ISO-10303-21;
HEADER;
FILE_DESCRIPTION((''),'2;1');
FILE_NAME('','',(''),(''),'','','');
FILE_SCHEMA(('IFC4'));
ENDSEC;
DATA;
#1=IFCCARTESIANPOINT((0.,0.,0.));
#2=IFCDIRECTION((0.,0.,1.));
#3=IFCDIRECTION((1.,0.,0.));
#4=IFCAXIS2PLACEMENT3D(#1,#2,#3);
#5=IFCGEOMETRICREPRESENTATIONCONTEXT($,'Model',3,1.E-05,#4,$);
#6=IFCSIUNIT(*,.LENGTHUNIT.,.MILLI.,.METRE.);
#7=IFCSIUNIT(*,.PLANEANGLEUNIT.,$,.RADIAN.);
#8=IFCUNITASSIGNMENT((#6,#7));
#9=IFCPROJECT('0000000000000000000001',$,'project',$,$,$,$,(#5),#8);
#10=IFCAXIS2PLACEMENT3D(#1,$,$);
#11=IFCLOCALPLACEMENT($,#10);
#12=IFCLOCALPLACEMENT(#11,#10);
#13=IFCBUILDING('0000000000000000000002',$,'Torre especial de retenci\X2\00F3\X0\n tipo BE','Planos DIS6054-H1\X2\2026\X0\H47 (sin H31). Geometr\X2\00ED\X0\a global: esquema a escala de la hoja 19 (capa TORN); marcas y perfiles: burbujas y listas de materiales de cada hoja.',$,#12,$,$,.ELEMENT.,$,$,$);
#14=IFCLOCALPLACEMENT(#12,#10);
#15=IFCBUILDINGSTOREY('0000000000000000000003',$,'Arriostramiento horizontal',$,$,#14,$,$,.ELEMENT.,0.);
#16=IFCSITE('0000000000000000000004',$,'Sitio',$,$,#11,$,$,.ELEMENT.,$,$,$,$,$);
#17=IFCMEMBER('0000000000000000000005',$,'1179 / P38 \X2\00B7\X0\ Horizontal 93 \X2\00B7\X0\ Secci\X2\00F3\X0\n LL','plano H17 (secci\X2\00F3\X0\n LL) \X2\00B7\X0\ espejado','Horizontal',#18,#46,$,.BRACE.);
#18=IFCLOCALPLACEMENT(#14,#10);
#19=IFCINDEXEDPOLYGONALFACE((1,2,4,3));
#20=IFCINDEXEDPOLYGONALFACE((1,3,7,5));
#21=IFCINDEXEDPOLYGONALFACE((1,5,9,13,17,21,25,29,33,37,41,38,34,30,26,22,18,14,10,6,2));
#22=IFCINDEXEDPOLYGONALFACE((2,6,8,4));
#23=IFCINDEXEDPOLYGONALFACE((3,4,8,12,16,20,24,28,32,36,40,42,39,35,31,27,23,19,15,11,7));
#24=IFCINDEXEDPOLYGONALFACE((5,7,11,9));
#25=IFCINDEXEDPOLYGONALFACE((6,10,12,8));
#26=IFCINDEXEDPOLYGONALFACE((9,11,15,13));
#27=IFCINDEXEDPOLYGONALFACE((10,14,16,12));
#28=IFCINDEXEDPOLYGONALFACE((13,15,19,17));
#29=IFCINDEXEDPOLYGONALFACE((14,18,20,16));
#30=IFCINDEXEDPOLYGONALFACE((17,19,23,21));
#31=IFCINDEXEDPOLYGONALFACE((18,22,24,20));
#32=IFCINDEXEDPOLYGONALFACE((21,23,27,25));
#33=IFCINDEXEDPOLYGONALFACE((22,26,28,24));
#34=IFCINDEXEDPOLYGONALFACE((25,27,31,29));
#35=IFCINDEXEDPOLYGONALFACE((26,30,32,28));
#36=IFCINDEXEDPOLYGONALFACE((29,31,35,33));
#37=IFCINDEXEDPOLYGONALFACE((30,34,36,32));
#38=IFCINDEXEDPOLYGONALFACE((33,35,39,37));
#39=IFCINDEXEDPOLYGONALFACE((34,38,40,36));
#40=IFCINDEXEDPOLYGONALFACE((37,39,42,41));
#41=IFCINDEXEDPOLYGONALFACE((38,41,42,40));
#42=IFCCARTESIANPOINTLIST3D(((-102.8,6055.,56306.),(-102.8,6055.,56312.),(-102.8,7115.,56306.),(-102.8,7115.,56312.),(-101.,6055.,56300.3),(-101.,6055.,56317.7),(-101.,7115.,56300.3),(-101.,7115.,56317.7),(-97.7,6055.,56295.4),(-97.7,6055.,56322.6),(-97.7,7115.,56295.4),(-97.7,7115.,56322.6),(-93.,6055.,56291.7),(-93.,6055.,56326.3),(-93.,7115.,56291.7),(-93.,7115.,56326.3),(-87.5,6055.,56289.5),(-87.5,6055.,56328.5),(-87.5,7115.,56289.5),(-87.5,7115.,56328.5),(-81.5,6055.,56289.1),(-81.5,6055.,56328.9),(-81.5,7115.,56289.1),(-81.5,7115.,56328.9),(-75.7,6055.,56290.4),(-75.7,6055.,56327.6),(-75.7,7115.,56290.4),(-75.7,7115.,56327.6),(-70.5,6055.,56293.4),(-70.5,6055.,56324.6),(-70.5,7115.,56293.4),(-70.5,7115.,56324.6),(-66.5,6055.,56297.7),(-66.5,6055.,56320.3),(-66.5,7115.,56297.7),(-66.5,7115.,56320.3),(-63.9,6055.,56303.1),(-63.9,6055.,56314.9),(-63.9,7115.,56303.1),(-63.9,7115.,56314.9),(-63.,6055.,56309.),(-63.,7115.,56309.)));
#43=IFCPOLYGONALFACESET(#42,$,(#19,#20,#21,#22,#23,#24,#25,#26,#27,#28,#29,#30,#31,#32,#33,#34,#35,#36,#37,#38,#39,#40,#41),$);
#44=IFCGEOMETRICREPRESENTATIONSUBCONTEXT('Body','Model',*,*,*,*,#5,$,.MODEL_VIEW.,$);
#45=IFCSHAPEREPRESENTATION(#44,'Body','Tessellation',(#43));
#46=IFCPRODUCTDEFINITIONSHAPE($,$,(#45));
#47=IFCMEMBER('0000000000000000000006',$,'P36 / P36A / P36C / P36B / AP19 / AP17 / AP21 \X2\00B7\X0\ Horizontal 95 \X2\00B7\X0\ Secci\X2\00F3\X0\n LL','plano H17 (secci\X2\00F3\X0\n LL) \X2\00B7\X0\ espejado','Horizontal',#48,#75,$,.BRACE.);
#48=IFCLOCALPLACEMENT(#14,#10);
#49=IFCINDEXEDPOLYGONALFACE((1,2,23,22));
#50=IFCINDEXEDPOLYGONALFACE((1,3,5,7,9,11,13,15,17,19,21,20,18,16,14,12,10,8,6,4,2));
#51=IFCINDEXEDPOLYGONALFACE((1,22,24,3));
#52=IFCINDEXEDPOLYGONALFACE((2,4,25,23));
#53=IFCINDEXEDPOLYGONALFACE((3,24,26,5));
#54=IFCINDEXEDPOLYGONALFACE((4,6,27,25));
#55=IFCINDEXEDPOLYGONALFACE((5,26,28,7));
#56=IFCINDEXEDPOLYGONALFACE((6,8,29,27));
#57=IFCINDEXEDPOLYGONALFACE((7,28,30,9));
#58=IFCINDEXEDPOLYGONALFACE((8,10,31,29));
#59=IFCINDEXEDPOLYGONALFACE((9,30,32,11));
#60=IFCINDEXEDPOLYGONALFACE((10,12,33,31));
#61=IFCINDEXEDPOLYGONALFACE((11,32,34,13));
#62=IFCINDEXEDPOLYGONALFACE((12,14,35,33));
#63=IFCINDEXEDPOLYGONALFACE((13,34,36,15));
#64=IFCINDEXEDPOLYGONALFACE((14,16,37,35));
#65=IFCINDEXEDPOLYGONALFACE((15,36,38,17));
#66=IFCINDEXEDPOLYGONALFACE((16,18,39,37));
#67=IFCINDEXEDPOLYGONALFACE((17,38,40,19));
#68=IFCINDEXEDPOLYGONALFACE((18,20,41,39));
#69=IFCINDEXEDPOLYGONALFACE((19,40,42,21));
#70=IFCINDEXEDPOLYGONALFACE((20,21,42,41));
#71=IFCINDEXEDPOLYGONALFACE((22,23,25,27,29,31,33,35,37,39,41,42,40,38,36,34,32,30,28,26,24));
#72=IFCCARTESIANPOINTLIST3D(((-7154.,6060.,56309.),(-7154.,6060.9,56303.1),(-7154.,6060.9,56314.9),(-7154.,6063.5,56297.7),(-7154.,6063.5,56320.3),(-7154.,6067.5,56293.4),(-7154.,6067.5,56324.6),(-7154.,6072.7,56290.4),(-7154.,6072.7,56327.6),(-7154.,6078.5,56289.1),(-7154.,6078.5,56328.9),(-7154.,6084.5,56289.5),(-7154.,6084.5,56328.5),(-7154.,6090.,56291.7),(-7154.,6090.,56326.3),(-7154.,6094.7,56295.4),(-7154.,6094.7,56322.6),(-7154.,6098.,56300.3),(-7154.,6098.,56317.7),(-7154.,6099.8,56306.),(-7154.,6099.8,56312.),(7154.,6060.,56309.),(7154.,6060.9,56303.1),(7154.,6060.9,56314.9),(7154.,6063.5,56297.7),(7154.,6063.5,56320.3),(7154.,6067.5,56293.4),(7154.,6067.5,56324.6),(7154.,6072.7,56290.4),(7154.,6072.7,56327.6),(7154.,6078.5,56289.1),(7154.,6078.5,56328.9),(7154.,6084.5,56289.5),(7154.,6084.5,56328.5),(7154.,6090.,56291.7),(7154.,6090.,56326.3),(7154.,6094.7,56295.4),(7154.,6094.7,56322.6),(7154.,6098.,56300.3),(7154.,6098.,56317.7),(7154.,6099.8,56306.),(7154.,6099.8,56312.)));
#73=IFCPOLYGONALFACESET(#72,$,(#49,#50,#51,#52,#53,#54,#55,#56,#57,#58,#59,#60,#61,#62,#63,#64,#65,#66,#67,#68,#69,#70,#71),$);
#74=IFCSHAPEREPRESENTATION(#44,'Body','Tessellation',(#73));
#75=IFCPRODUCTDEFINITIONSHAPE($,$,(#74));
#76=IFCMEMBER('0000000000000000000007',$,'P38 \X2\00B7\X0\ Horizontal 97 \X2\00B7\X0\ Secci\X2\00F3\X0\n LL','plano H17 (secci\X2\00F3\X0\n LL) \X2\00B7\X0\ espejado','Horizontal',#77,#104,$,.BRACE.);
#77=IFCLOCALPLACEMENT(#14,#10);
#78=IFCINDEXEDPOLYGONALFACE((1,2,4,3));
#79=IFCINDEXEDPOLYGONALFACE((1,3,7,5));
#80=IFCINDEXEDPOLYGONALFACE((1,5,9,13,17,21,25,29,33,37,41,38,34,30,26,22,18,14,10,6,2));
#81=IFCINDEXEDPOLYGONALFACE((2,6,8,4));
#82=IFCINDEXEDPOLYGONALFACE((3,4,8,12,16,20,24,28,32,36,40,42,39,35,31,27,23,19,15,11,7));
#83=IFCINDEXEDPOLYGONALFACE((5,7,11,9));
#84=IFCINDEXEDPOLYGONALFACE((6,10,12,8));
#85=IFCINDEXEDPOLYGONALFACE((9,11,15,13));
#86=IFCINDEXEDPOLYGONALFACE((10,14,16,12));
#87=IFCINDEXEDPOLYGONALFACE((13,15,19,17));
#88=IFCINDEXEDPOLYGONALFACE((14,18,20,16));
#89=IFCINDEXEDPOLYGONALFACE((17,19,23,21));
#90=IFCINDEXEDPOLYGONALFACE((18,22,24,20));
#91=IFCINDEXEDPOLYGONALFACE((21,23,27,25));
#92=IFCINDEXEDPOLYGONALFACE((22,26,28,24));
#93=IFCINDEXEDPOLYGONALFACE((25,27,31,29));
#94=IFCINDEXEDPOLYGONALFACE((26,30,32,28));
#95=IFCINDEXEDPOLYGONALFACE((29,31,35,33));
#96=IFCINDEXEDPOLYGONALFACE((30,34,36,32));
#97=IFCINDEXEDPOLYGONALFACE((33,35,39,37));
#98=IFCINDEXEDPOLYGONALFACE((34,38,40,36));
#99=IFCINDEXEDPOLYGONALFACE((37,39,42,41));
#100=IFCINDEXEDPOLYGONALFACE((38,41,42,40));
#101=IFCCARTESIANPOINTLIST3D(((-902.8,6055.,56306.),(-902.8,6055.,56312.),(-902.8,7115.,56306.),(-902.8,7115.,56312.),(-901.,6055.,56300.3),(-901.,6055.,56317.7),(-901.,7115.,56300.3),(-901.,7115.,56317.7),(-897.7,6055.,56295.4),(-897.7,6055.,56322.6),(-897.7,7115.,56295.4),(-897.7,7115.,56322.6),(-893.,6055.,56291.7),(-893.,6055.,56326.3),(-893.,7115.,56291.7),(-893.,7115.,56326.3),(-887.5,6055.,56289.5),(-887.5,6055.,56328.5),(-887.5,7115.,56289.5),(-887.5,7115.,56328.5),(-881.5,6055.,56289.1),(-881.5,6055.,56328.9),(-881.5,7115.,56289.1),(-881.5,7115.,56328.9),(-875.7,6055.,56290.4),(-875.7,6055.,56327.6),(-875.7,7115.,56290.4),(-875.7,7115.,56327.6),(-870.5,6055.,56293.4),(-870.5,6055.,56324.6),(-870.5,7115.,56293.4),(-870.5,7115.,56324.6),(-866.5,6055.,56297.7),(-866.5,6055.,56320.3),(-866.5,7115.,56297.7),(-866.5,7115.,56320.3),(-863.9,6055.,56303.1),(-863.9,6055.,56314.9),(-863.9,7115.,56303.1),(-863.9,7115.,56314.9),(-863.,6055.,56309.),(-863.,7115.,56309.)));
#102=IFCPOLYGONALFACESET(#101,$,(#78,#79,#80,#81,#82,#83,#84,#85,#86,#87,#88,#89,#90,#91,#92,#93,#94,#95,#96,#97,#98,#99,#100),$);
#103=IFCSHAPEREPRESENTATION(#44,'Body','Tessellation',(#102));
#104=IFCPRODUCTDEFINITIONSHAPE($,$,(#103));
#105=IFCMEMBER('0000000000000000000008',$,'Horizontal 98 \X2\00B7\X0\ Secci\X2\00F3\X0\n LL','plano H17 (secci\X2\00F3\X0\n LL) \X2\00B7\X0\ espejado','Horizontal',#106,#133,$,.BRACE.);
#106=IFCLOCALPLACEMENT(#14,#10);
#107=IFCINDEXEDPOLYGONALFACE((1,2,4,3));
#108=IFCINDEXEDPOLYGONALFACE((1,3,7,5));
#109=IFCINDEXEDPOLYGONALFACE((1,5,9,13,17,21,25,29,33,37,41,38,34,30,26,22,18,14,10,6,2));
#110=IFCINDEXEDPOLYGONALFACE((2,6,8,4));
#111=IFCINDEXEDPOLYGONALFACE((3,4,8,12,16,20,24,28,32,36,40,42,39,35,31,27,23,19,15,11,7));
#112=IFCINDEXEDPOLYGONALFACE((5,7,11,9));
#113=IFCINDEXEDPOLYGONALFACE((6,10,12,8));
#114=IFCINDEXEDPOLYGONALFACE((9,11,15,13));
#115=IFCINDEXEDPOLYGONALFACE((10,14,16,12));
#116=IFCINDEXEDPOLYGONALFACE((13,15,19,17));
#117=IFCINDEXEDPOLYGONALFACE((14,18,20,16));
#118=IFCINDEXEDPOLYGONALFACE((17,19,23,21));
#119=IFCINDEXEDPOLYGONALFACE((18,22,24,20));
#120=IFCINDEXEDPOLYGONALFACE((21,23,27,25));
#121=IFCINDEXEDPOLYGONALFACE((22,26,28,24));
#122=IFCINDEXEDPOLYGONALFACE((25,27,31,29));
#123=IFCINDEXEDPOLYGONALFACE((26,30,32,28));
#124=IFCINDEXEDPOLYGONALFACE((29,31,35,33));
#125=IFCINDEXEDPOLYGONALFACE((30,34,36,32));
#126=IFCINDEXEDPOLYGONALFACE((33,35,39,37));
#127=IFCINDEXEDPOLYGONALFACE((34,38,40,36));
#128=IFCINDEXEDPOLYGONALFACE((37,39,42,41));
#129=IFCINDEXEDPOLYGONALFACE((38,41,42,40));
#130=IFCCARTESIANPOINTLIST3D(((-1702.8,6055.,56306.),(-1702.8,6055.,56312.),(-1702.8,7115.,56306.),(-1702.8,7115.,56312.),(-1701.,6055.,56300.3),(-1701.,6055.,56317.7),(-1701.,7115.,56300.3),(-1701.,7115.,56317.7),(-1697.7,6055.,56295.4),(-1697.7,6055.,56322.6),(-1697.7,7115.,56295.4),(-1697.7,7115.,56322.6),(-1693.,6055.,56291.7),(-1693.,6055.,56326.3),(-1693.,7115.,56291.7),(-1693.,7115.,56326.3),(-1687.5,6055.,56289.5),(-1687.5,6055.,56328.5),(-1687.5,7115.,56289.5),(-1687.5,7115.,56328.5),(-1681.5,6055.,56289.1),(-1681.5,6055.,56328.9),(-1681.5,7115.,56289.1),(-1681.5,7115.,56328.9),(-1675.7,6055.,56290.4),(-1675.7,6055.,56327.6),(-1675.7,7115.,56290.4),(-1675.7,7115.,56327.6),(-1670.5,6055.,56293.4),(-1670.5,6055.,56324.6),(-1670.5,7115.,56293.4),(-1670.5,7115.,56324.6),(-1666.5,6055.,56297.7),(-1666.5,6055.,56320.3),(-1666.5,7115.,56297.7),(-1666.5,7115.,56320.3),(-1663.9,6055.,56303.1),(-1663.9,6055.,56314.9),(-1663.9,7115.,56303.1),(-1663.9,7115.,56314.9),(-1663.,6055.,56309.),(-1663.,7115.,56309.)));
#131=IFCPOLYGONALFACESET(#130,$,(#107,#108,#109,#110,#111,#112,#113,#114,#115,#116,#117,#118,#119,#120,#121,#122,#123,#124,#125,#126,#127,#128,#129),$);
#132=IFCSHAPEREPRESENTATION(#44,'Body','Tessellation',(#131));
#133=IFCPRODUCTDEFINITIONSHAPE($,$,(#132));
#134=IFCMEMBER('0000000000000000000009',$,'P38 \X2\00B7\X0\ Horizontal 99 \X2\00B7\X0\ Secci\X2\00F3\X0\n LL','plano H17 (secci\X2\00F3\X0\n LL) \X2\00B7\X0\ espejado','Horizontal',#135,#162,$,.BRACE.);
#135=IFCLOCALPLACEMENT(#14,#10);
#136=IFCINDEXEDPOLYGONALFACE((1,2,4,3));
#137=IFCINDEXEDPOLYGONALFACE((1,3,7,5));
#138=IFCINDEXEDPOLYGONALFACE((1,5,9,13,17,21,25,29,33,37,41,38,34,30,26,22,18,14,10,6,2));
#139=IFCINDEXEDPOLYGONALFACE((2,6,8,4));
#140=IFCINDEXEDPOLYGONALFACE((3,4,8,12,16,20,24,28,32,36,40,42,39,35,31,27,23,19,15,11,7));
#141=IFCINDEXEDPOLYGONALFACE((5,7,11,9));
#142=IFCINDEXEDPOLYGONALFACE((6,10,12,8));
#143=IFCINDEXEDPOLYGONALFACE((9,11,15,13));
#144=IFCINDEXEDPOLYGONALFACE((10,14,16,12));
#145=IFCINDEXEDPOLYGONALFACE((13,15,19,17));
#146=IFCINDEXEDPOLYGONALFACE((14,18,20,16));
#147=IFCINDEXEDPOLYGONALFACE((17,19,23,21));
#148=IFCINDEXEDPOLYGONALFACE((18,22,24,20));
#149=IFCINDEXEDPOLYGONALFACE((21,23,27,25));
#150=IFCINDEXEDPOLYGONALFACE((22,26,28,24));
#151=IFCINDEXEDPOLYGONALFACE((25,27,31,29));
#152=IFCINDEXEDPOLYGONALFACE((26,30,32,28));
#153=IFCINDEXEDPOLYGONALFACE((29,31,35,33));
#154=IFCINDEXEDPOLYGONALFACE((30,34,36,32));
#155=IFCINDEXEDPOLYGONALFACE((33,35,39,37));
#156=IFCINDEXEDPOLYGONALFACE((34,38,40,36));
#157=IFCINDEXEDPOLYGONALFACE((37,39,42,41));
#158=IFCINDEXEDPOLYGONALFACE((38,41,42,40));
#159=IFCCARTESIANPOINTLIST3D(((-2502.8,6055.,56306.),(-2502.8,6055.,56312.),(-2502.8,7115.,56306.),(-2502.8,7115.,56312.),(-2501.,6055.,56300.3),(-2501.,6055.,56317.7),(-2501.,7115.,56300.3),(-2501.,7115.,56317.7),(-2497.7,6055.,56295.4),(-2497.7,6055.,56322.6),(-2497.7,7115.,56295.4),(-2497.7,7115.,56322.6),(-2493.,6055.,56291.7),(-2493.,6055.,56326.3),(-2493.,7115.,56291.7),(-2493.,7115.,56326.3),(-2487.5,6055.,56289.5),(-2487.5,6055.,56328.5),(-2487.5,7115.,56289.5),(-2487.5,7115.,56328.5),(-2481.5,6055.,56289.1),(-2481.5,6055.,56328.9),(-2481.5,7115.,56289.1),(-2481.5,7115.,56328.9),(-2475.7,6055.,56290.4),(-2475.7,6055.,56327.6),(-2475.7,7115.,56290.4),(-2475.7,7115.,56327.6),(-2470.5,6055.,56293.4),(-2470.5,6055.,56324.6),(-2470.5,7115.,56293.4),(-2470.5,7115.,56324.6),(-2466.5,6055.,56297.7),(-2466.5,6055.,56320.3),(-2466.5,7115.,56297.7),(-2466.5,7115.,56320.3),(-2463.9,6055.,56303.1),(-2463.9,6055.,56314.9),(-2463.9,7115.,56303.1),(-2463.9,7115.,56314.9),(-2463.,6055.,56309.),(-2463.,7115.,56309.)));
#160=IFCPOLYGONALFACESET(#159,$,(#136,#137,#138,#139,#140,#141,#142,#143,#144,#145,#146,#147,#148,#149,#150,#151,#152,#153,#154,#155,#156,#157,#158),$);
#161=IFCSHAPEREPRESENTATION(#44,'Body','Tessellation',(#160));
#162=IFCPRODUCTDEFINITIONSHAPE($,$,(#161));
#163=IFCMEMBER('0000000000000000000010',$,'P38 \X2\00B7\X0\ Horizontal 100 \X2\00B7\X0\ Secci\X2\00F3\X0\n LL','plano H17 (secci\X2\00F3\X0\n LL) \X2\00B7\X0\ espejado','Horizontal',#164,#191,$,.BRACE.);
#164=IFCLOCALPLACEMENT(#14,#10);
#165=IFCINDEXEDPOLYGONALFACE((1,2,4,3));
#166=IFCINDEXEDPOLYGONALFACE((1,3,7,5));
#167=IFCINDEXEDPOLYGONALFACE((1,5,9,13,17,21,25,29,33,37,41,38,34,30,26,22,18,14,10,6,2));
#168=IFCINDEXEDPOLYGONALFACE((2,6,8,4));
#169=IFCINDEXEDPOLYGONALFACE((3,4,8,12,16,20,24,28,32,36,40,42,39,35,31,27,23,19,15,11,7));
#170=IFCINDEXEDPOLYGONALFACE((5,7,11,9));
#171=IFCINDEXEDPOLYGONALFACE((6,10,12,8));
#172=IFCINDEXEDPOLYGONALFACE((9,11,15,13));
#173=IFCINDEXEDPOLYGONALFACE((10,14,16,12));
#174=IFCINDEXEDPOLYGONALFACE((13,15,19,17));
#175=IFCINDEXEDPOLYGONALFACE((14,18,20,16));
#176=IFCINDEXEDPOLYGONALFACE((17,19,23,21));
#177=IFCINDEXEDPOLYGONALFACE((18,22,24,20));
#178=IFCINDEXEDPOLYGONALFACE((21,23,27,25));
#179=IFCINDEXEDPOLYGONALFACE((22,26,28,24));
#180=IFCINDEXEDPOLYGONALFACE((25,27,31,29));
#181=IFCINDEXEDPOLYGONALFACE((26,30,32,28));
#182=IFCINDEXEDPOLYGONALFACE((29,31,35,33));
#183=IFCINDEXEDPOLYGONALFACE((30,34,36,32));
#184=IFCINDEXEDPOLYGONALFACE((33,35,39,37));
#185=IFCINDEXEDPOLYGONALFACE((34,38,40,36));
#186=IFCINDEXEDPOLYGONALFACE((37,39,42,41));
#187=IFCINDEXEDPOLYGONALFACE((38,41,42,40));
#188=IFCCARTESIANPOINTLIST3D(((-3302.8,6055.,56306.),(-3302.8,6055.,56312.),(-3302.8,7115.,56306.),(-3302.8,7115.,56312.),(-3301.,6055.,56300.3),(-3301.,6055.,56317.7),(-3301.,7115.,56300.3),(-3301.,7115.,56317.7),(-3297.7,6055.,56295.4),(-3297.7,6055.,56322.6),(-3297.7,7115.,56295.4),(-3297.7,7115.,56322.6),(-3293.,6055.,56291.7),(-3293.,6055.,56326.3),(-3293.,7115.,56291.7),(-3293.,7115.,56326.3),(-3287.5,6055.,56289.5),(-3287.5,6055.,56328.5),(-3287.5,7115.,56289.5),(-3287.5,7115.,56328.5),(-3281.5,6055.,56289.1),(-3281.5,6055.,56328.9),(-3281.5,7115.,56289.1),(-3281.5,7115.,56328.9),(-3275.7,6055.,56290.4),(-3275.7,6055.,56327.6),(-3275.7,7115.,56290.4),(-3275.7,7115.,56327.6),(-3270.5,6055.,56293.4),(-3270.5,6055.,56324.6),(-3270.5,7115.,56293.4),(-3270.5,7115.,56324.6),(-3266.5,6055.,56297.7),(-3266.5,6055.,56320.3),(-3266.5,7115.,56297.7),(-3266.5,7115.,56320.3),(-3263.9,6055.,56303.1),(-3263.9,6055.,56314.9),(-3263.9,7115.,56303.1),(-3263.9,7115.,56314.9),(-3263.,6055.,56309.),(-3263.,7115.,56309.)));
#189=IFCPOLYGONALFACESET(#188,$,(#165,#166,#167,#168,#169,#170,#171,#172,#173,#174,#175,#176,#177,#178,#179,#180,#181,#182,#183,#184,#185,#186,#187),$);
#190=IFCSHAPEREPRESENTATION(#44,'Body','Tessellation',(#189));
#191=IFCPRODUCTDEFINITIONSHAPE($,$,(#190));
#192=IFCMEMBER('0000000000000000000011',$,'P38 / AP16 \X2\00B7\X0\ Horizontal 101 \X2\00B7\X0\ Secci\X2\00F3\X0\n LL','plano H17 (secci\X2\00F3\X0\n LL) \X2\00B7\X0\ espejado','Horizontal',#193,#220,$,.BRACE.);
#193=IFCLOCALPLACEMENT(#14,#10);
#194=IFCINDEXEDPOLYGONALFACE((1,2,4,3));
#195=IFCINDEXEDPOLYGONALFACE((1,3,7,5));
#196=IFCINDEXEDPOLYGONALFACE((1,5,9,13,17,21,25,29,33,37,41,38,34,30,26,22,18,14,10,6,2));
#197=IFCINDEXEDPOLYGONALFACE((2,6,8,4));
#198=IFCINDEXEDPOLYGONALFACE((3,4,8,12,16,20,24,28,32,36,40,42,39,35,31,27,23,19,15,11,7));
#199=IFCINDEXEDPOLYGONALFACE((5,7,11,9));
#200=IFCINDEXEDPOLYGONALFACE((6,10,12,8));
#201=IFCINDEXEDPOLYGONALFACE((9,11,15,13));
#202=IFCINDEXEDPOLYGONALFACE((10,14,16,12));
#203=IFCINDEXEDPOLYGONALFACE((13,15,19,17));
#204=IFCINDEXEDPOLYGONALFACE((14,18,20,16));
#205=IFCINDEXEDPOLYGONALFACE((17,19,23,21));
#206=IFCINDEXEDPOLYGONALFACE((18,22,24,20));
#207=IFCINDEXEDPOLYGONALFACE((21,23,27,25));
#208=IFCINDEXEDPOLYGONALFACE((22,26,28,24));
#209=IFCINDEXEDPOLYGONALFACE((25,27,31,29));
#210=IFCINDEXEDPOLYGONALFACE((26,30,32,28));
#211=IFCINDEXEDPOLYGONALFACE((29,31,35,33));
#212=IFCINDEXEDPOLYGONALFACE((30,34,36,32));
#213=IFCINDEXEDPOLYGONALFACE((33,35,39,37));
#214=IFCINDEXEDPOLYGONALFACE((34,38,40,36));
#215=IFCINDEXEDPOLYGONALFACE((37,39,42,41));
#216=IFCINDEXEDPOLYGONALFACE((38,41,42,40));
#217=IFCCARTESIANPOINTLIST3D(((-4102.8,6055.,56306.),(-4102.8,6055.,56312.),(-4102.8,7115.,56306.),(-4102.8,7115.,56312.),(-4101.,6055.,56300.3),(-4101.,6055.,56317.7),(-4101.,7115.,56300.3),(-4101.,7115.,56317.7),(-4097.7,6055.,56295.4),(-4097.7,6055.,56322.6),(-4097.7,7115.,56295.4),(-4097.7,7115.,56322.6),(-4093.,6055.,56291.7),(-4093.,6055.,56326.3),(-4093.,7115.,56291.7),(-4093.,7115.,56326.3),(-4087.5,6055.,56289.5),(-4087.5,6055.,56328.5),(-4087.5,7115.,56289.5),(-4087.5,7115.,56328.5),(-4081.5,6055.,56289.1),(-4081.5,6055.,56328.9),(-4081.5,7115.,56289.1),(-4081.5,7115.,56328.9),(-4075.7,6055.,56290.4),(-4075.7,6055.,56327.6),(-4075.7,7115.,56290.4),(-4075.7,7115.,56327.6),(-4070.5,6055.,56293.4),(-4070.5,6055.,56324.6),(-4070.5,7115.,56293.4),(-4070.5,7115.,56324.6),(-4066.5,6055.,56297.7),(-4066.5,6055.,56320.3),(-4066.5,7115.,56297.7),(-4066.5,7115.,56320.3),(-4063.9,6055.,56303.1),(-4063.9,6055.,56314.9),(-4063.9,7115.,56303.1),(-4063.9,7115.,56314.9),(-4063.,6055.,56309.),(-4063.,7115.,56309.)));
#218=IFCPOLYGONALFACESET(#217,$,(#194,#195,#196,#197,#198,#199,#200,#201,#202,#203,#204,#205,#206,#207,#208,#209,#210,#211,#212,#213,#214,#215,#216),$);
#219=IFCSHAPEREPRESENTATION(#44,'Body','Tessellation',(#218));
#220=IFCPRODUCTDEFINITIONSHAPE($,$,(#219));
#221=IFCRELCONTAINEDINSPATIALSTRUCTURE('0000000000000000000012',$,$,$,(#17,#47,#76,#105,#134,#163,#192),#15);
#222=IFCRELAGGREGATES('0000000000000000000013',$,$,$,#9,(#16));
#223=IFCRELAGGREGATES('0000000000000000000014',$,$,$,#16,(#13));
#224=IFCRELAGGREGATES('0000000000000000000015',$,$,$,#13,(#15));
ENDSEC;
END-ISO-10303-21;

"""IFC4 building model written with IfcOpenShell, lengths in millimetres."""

from ifc_helpers import new_model, si_unit, frame, origin, origin_with_axes, place, context, subcontext, project, spatial, circle, extrude, element, save


model = new_model("IFC4")

# Units and contexts
model_context = context("Model", 3, precision=1e-05, world=origin_with_axes())
body_context = subcontext(model_context, "Body", "Model", "MODEL_VIEW")
ifc_project = project(units=[si_unit("LENGTHUNIT", "METRE", prefix="MILLI"), si_unit("PLANEANGLEUNIT", "RADIAN")], contexts=[model_context])

# Site, building, storey
site_placement = place(None, origin())
site = spatial("IfcSite", under=ifc_project, at=site_placement, Name="Sitio", CompositionType="ELEMENT")
building_placement = place(site_placement, origin())
building = spatial("IfcBuilding", under=site, at=building_placement, Name="Torre especial de retención tipo BE", Description="Planos DIS6054-H1…H47 (sin H31). Geometría global: esquema a escala de la hoja 19 (capa TORN); marcas y perfiles: burbujas y listas de materiales de cada hoja.", CompositionType="ELEMENT")
storey_placement = place(building_placement, origin())
storey = spatial("IfcBuildingStorey", under=building, at=storey_placement, Name="Arriostramiento horizontal", CompositionType="ELEMENT", Elevation=0.0)

# Members
member_1_placement = place(storey_placement, frame((-83.0, 7115.0, 56309.0), z_axis=(0.0, -1.0, 0.0), x_axis=(1.0, 0.0, 0.0)))
element("IfcMember", 1, at=member_1_placement, inside=storey, Name="1179 / P38 · Horizontal 93 · Sección LL", Description="plano H17 (sección LL) · espejado", ObjectType="Horizontal", PredefinedType="BRACE", context=body_context, shape_type="SweptSolid", body=[
    extrude(circle(Radius=20.0), None, (0.0, 0.0, 1.0), 1060.0),
])
member_2_placement = place(storey_placement, frame((-7154.0, 6080.0, 56309.0), z_axis=(1.0, 0.0, 0.0), x_axis=(0.0, -1.0, 0.0)))
element("IfcMember", 2, at=member_2_placement, inside=storey, Name="P36 / P36A / P36C / P36B / AP19 / AP17 / AP21 · Horizontal 95 · Sección LL", Description="plano H17 (sección LL) · espejado", ObjectType="Horizontal", PredefinedType="BRACE", context=body_context, shape_type="SweptSolid", body=[
    extrude(circle(Radius=20.0), None, (0.0, 0.0, 1.0), 14308.0),
])
for number, where, z_axis, x_axis, name in (
    (3, (-883.0, 7115.0, 56309.0), (0.0, -1.0, 0.0), (1.0, 0.0, 0.0), "P38 · Horizontal 97 · Sección LL"),
    (4, (-1683.0, 7115.0, 56309.0), (0.0, -1.0, 0.0), (1.0, 0.0, 0.0), "Horizontal 98 · Sección LL"),
    (5, (-2483.0, 7115.0, 56309.0), (0.0, -1.0, 0.0), (1.0, 0.0, 0.0), "P38 · Horizontal 99 · Sección LL"),
    (6, (-3283.0, 7115.0, 56309.0), (0.0, -1.0, 0.0), (1.0, 0.0, 0.0), "P38 · Horizontal 100 · Sección LL"),
    (7, (-4083.0, 7115.0, 56309.0), (0.0, -1.0, 0.0), (1.0, 0.0, 0.0), "P38 / AP16 · Horizontal 101 · Sección LL"),
):
    element("IfcMember", number, at=place(storey_placement, frame(where, z_axis=z_axis, x_axis=x_axis)), inside=storey, Name=name, Description="plano H17 (sección LL) · espejado", ObjectType="Horizontal", PredefinedType="BRACE", context=body_context, shape_type="SweptSolid", body=[
        extrude(circle(Radius=20.0), None, (0.0, 0.0, 1.0), 1060.0),
    ])

save(model, "model.ifc")
